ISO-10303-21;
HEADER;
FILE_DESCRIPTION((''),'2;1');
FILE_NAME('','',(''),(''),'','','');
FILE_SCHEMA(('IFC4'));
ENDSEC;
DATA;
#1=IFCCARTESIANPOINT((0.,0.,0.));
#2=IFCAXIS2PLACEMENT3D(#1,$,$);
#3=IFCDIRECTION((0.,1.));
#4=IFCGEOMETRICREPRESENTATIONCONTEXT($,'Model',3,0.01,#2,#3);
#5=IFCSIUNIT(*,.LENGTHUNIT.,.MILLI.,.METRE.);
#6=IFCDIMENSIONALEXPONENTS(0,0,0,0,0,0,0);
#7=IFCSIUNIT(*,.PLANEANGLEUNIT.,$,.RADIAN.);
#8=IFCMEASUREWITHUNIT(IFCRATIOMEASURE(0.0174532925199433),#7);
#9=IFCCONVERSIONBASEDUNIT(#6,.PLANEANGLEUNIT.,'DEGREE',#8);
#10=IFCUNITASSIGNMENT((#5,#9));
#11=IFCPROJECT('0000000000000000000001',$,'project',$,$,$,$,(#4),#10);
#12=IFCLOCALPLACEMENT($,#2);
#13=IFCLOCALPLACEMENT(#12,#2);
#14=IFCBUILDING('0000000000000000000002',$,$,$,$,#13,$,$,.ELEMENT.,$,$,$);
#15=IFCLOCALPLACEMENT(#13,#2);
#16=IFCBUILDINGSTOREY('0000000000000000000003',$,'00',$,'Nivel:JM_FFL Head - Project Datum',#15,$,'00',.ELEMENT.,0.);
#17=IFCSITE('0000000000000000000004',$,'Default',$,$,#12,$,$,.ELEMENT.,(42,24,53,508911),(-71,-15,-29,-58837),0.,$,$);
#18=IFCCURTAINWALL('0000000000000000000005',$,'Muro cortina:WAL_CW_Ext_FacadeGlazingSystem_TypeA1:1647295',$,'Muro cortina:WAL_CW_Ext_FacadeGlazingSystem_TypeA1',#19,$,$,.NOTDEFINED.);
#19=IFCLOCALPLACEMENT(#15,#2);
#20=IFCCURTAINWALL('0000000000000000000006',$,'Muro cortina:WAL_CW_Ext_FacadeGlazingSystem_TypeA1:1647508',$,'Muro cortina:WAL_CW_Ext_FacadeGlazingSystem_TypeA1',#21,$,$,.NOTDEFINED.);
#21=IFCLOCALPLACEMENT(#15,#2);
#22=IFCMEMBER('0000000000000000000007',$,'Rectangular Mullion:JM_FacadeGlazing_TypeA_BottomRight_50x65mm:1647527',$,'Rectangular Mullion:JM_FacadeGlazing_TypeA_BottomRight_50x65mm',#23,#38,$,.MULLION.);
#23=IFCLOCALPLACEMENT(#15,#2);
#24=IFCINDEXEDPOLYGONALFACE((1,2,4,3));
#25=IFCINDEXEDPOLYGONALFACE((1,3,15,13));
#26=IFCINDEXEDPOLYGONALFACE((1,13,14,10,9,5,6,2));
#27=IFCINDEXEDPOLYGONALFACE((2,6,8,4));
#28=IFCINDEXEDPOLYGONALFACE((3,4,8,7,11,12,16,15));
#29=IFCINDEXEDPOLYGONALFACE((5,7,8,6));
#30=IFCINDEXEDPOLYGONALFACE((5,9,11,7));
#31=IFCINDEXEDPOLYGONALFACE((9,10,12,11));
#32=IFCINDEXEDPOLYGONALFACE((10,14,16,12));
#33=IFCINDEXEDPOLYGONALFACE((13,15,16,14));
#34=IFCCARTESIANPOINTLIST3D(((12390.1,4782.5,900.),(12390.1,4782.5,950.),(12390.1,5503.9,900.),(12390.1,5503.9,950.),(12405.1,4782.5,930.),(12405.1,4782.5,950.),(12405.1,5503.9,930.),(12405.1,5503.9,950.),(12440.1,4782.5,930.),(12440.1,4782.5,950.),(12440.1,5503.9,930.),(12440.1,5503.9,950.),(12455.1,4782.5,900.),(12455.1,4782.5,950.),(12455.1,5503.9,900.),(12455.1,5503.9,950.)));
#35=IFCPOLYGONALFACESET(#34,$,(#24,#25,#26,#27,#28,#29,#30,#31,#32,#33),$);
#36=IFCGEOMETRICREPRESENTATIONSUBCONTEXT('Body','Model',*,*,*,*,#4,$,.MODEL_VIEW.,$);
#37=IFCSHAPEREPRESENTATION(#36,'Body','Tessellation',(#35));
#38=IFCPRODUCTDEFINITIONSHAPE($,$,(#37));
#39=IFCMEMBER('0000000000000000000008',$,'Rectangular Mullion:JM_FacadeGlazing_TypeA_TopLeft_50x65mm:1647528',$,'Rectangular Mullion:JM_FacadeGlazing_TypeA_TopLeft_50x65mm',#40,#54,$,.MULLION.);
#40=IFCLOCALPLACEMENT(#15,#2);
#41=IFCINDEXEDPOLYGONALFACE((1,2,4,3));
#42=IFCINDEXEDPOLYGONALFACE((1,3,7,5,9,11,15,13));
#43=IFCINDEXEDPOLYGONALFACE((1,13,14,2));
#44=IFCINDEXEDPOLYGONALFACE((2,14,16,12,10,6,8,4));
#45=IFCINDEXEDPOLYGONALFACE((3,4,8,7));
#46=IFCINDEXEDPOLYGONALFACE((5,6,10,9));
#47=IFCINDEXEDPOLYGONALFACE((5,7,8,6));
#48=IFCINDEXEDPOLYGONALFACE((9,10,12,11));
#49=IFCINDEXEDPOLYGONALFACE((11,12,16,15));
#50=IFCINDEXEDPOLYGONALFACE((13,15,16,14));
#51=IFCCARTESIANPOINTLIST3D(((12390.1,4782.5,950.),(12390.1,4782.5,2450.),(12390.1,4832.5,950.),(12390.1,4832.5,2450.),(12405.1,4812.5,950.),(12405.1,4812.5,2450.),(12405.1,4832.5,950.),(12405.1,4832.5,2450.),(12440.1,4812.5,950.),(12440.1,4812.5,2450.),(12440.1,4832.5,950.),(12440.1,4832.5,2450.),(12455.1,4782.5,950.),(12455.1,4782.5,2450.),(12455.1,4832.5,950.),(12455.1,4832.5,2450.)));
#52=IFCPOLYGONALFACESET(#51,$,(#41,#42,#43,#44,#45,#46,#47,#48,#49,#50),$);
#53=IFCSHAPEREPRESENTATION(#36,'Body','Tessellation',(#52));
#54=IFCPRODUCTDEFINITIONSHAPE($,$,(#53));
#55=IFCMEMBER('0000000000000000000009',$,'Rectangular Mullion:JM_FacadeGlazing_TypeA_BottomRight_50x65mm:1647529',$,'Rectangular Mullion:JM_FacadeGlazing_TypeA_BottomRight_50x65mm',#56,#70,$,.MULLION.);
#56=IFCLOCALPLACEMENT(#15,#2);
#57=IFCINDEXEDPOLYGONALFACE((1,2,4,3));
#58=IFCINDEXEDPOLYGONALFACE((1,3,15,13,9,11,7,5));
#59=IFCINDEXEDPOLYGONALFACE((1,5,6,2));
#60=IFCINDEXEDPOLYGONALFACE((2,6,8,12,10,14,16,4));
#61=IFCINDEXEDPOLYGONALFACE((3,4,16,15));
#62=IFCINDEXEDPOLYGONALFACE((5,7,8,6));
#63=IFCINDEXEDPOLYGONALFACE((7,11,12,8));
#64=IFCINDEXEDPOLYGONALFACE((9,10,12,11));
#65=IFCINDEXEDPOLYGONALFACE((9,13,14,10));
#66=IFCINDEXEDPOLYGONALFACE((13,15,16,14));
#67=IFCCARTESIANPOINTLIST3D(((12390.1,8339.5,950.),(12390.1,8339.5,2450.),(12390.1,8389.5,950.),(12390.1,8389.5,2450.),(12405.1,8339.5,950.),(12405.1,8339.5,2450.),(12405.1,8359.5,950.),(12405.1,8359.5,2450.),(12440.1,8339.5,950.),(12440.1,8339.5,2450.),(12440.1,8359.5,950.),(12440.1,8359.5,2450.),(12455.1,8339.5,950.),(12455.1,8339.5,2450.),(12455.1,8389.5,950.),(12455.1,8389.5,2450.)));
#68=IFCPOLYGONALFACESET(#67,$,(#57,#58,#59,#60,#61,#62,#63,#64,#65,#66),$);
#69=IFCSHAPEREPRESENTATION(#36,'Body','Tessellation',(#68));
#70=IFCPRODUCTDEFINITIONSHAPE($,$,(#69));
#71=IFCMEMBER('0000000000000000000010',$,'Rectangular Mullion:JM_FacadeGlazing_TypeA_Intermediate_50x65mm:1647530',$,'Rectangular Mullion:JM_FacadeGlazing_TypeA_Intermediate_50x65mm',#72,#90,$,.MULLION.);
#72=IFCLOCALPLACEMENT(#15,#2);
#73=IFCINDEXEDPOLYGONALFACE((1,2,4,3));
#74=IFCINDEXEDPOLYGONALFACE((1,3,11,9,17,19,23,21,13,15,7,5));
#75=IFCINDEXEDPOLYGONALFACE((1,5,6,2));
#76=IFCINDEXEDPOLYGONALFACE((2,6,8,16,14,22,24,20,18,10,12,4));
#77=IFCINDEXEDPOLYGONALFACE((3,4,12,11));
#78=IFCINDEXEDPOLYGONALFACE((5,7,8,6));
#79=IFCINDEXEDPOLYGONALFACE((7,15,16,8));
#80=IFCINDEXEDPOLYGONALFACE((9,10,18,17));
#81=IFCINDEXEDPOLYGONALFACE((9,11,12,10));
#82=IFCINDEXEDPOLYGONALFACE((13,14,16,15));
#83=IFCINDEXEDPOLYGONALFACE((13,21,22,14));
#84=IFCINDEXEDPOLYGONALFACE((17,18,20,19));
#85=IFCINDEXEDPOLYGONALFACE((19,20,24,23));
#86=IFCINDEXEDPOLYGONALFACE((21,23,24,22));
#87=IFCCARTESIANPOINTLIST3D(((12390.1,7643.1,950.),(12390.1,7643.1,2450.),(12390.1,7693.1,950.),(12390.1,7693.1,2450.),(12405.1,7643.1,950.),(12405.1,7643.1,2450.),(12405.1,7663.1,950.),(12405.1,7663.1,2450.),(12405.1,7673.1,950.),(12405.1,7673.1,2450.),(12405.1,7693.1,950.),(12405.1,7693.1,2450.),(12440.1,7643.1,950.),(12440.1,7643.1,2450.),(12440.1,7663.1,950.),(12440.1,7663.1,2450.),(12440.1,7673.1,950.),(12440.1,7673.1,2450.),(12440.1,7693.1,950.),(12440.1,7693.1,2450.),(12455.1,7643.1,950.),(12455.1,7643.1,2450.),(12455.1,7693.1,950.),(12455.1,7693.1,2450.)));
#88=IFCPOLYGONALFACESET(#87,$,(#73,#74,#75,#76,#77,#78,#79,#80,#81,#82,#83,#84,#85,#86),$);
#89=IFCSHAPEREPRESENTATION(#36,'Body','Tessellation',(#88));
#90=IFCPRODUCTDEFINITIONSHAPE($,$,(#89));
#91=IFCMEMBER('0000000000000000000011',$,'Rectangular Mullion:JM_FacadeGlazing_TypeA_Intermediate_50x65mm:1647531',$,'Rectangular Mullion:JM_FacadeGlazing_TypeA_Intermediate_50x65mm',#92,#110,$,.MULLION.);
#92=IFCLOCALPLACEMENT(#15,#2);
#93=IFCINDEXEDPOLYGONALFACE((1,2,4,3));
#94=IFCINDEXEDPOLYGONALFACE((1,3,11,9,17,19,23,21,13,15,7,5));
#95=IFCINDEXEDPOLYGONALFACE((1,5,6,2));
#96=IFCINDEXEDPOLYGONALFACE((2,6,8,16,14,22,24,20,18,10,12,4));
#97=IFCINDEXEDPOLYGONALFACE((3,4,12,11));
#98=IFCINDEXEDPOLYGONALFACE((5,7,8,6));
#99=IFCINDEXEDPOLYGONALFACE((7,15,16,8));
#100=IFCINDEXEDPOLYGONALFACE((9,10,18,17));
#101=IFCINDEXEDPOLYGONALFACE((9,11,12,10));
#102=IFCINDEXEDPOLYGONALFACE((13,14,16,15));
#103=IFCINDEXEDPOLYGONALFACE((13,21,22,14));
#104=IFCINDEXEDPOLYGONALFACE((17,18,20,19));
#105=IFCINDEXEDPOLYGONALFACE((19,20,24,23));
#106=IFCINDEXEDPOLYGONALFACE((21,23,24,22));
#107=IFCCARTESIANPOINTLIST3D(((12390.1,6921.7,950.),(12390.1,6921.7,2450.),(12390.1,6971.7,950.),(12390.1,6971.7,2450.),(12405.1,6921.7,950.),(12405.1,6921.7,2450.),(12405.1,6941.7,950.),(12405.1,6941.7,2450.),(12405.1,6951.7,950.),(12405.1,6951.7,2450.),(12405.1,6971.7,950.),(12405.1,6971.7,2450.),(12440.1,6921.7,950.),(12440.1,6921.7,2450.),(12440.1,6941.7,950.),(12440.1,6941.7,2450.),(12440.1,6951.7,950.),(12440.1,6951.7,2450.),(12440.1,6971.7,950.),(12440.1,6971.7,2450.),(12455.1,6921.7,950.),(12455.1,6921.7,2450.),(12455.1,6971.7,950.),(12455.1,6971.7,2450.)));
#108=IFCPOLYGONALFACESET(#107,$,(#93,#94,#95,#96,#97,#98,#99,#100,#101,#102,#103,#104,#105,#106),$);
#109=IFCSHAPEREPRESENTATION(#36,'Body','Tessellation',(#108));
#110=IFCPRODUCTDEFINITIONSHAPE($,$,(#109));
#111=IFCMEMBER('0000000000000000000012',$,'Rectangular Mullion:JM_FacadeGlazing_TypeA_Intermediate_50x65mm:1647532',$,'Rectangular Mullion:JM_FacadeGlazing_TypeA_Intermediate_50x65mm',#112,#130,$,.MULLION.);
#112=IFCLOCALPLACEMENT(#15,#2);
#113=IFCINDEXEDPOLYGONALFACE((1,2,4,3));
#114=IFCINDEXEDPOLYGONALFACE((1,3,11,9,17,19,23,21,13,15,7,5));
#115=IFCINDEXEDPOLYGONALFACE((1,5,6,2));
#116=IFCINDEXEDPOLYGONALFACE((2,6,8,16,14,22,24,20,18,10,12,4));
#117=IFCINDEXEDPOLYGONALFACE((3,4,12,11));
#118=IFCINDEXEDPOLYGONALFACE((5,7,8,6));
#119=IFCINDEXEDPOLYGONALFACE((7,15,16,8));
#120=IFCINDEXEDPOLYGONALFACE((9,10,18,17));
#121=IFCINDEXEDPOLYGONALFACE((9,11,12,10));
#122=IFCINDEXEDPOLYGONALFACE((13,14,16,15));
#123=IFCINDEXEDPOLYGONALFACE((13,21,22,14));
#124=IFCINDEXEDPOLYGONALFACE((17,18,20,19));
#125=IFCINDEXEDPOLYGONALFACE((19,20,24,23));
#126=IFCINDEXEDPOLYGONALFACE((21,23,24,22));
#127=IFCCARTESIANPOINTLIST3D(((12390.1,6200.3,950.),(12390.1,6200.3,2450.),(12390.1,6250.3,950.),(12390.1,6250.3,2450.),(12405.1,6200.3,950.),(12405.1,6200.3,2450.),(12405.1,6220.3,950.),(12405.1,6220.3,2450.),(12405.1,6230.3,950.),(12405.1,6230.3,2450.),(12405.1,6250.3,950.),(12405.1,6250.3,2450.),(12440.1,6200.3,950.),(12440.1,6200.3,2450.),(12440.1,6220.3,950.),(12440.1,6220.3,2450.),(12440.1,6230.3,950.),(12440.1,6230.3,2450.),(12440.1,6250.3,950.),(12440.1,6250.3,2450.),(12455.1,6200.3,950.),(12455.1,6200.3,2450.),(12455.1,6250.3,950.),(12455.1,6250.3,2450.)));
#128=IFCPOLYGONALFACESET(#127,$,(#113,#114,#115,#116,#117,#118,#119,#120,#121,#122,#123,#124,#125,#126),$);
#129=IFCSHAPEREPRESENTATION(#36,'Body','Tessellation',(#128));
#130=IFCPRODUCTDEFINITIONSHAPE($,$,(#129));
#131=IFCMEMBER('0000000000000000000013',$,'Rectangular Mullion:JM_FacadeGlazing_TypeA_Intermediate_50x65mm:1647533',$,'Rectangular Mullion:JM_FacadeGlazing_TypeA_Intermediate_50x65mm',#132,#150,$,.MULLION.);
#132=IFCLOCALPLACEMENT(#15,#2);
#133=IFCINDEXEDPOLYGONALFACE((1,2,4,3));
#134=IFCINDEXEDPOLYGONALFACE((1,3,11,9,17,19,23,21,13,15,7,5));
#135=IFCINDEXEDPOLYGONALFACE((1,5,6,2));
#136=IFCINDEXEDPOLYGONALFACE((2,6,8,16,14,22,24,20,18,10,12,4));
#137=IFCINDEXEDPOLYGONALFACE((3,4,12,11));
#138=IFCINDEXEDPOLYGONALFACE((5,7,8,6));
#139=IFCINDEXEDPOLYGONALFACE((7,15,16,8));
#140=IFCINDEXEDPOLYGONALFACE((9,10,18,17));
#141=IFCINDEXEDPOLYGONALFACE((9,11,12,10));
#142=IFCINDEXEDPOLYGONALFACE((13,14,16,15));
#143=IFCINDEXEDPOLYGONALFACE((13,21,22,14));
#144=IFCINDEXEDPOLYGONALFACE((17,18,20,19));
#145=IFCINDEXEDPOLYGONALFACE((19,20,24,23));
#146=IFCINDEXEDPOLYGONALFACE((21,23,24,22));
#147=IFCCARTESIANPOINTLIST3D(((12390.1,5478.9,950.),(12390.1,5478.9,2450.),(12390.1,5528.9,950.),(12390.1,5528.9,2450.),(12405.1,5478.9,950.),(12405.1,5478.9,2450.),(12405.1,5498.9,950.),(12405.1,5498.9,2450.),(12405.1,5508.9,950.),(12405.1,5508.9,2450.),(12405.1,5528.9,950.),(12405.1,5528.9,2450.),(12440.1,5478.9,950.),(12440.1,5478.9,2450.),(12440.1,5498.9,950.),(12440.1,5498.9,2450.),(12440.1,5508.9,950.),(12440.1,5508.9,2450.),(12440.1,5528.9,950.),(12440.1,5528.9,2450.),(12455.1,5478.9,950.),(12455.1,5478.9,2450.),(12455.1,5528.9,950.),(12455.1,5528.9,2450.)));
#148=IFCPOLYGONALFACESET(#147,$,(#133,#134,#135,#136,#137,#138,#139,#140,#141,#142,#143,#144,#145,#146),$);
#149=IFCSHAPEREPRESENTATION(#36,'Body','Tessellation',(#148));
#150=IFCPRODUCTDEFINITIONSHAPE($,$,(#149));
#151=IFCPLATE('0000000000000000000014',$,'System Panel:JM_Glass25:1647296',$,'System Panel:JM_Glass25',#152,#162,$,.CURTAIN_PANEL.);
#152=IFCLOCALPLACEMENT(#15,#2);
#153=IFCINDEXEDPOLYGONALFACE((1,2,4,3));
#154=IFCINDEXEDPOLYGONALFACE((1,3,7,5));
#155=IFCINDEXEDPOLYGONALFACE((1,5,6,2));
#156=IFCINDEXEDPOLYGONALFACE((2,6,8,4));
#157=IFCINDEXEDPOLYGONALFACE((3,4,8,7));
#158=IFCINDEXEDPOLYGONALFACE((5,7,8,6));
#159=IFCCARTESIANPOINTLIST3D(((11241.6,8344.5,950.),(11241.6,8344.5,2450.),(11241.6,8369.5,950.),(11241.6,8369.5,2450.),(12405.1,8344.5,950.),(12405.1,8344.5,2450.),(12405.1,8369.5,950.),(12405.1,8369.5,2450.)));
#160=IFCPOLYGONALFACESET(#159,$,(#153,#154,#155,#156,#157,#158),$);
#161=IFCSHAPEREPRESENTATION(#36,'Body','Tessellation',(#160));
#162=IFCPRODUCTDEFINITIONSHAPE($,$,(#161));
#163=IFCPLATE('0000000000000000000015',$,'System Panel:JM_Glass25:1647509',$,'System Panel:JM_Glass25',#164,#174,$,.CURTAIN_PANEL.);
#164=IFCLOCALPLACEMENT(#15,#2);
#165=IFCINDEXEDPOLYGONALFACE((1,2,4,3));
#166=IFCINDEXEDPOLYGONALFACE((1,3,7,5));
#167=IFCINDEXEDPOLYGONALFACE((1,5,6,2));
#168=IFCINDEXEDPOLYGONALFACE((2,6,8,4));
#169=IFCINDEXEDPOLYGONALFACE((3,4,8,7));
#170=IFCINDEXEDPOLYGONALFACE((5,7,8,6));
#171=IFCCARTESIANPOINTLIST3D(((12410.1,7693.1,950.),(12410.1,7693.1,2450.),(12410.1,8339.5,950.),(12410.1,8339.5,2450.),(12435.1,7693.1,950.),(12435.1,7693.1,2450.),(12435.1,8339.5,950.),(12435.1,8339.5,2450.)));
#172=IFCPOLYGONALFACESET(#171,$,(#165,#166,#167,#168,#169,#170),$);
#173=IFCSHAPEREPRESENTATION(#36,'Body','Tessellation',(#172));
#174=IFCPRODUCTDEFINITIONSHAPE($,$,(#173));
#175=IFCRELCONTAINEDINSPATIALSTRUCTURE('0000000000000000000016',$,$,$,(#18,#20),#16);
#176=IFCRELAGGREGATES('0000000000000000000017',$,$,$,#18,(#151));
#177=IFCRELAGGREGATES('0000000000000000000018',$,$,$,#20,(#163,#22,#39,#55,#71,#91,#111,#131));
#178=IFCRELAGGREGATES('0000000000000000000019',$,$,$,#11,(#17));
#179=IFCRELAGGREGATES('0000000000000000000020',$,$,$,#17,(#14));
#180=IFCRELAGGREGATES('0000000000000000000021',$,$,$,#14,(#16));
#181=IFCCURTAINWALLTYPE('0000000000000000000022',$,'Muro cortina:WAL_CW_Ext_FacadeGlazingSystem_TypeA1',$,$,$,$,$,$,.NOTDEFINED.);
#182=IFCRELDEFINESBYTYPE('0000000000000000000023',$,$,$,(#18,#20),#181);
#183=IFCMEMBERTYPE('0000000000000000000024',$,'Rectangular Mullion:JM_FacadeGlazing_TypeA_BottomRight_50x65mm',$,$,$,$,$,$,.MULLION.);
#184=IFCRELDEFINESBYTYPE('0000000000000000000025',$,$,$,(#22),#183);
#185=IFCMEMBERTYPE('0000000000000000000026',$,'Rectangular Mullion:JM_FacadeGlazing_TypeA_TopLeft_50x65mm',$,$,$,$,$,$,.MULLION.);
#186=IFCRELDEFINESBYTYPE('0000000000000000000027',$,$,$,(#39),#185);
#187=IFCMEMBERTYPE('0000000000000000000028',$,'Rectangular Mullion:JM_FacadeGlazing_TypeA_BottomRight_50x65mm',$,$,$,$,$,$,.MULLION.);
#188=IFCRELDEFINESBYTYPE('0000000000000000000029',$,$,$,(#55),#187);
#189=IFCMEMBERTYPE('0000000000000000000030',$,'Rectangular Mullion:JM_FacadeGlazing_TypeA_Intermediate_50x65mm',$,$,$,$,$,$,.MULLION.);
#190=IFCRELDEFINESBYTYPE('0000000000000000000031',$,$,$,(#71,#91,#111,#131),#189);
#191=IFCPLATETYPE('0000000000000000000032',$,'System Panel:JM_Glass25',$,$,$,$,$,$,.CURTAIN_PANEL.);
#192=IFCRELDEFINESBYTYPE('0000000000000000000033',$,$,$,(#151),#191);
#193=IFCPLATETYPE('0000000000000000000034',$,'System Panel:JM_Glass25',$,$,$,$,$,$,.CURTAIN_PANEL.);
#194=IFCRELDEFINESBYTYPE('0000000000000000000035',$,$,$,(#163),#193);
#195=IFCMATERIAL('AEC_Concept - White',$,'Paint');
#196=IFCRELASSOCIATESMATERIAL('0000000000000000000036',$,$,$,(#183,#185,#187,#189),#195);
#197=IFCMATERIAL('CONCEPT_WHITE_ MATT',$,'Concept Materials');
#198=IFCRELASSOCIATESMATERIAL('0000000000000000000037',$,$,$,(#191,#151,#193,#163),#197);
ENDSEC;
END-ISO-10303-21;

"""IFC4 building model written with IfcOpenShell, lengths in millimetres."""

from ifc_helpers import new_model, entity, si_unit, converted_unit, direction, frame, origin, place, context, subcontext, project, spatial, indexed_curve, outline, extrude, source, transform, mapped, material, type_object, type_shapes, element, aggregate, save


model = new_model("IFC4")

# Units and contexts
model_context = context("Model", 3, precision=0.01, world=origin(), true_north=direction((0.0, 1.0)))
body_context = subcontext(model_context, "Body", "Model", "MODEL_VIEW")
ifc_project = project(units=[si_unit("LENGTHUNIT", "METRE", prefix="MILLI"), converted_unit("PLANEANGLEUNIT", "DEGREE", entity("IfcRatioMeasure", 0.0174532925199433), si_unit("PLANEANGLEUNIT", "RADIAN"), dimensions=[0, 0, 0, 0, 0, 0, 0])], contexts=[model_context])

# Site, building, storey
site_placement = place(None, origin())
site = spatial("IfcSite", under=ifc_project, at=site_placement, Name="Default", CompositionType="ELEMENT", RefLatitude=(42, 24, 53, 508911), RefLongitude=(-71, -15, -29, -58837), RefElevation=0.0)
building_placement = place(site_placement, origin())
building = spatial("IfcBuilding", under=site, at=building_placement, CompositionType="ELEMENT")
storey_placement = place(building_placement, origin())
storey = spatial("IfcBuildingStorey", under=building, at=storey_placement, Name="00", ObjectType="Nivel:JM_FFL Head - Project Datum", LongName="00", CompositionType="ELEMENT", Elevation=0.0)

# Curtain walls, members
curtain_wall_type = type_object("IfcCurtainWallType", Name="Muro cortina:WAL_CW_Ext_FacadeGlazingSystem_TypeA1", PredefinedType="NOTDEFINED")
curtain_wall_1_placement = place(storey_placement, origin())
curtain_wall_1 = element("IfcCurtainWall", 1, at=curtain_wall_1_placement, inside=storey, type_object=curtain_wall_type, Name="Muro cortina:WAL_CW_Ext_FacadeGlazingSystem_TypeA1:1647295", ObjectType="Muro cortina:WAL_CW_Ext_FacadeGlazingSystem_TypeA1", PredefinedType="NOTDEFINED")
ifc_material_1 = material(Name="AEC_Concept - White", Category="Paint")
curtain_wall_2_placement = place(storey_placement, origin())
curtain_wall_2 = element("IfcCurtainWall", 2, at=curtain_wall_2_placement, inside=storey, type_object=curtain_wall_type, Name="Muro cortina:WAL_CW_Ext_FacadeGlazingSystem_TypeA1:1647508", ObjectType="Muro cortina:WAL_CW_Ext_FacadeGlazingSystem_TypeA1", PredefinedType="NOTDEFINED")
member_type_1 = type_object("IfcMemberType", Name="Rectangular Mullion:JM_FacadeGlazing_TypeA_BottomRight_50x65mm", PredefinedType="MULLION", material=ifc_material_1)
shared_shape_1 = source(origin(), body_context, "Body", "SweptSolid", [
    extrude(outline(indexed_curve([(-32.5, -17.5), (-17.5, -17.5), (-17.5, 2.5), (17.5, 2.5), (17.5, -17.5), (32.5, -17.5), (32.5, 32.5), (-32.5, 32.5), (-32.5, -17.5)], self_intersect=False)), frame((-32.5, 32.5, -721.4), z_axis=(0.0, 0.0, 1.0), x_axis=(0.0, -1.0, 0.0)), (0.0, 0.0, 1.0), 721.4),
])
type_shapes(member_type_1, [shared_shape_1])
member_1_placement = place(curtain_wall_2_placement, frame((12455.1, 5503.9, 900.0), z_axis=(0.0, 1.0, 0.0), x_axis=(0.0, 0.0, -1.0)))
member_1 = element("IfcMember", 3, at=member_1_placement, type_object=member_type_1, Name="Rectangular Mullion:JM_FacadeGlazing_TypeA_BottomRight_50x65mm:1647527", ObjectType="Rectangular Mullion:JM_FacadeGlazing_TypeA_BottomRight_50x65mm", PredefinedType="MULLION", context=body_context, shape_type="MappedRepresentation", body=[
    mapped(shared_shape_1, transform((0.0, 0.0, 0.0), scale=1.0)),
])
member_type_2 = type_object("IfcMemberType", Name="Rectangular Mullion:JM_FacadeGlazing_TypeA_TopLeft_50x65mm", PredefinedType="MULLION", material=ifc_material_1)
shared_shape_2 = source(origin(), body_context, "Body", "SweptSolid", [
    extrude(outline(indexed_curve([(-32.5, -17.5), (-17.5, -17.5), (-17.5, 2.5), (17.5, 2.5), (17.5, -17.5), (32.5, -17.5), (32.5, 32.5), (-32.5, 32.5), (-32.5, -17.5)], self_intersect=False)), frame((-32.5, 32.5, -1500.0), z_axis=(0.0, 0.0, 1.0), x_axis=(0.0, -1.0, 0.0)), (0.0, 0.0, 1.0), 1500.0),
])
type_shapes(member_type_2, [shared_shape_2])
member_2_placement = place(curtain_wall_2_placement, frame((12455.1, 4782.5, 950.0), z_axis=(0.0, 0.0, -1.0), x_axis=(0.0, -1.0, 0.0)))
member_2 = element("IfcMember", 4, at=member_2_placement, type_object=member_type_2, Name="Rectangular Mullion:JM_FacadeGlazing_TypeA_TopLeft_50x65mm:1647528", ObjectType="Rectangular Mullion:JM_FacadeGlazing_TypeA_TopLeft_50x65mm", PredefinedType="MULLION", context=body_context, shape_type="MappedRepresentation", body=[
    mapped(shared_shape_2, transform((0.0, 0.0, 0.0), scale=1.0)),
])
member_type_3 = type_object("IfcMemberType", Name="Rectangular Mullion:JM_FacadeGlazing_TypeA_BottomRight_50x65mm", PredefinedType="MULLION", material=ifc_material_1)
shared_shape_3 = source(origin(), body_context, "Body", "SweptSolid", [
    extrude(outline(indexed_curve([(-32.5, -17.5), (-17.5, -17.5), (-17.5, 2.5), (17.5, 2.5), (17.5, -17.5), (32.5, -17.5), (32.5, 32.5), (-32.5, 32.5), (-32.5, -17.5)], self_intersect=False)), frame((-32.5, 32.5, -1500.0), z_axis=(0.0, 0.0, 1.0), x_axis=(0.0, -1.0, 0.0)), (0.0, 0.0, 1.0), 1500.0),
])
type_shapes(member_type_3, [shared_shape_3])
member_3_placement = place(curtain_wall_2_placement, frame((12455.1, 8389.5, 2450.0), z_axis=(0.0, 0.0, 1.0), x_axis=(0.0, 1.0, 0.0)))
member_3 = element("IfcMember", 5, at=member_3_placement, type_object=member_type_3, Name="Rectangular Mullion:JM_FacadeGlazing_TypeA_BottomRight_50x65mm:1647529", ObjectType="Rectangular Mullion:JM_FacadeGlazing_TypeA_BottomRight_50x65mm", PredefinedType="MULLION", context=body_context, shape_type="MappedRepresentation", body=[
    mapped(shared_shape_3, transform((0.0, 0.0, 0.0), scale=1.0)),
])
member_type_4 = type_object("IfcMemberType", Name="Rectangular Mullion:JM_FacadeGlazing_TypeA_Intermediate_50x65mm", PredefinedType="MULLION", material=ifc_material_1)
shared_shape_4 = source(origin(), body_context, "Body", "SweptSolid", [
    extrude(outline(indexed_curve([(-32.5, -25.0), (-17.5, -25.0), (-17.5, -5.0), (17.5, -5.0), (17.5, -25.0), (32.5, -25.0), (32.5, 25.0), (17.5, 25.0), (17.5, 5.0), (-17.5, 5.0), (-17.5, 25.0), (-32.5, 25.0), (-32.5, -25.0)], self_intersect=False)), frame((0.0, 32.5, -1500.0), z_axis=(0.0, 0.0, 1.0), x_axis=(0.0, -1.0, 0.0)), (0.0, 0.0, 1.0), 1500.0),
])
type_shapes(member_type_4, [shared_shape_4])
member_4_placement = place(curtain_wall_2_placement, frame((12455.1, 7668.1, 950.0), z_axis=(0.0, 0.0, -1.0), x_axis=(0.0, -1.0, 0.0)))
member_4 = element("IfcMember", 6, at=member_4_placement, type_object=member_type_4, Name="Rectangular Mullion:JM_FacadeGlazing_TypeA_Intermediate_50x65mm:1647530", ObjectType="Rectangular Mullion:JM_FacadeGlazing_TypeA_Intermediate_50x65mm", PredefinedType="MULLION", context=body_context, shape_type="MappedRepresentation", body=[
    mapped(shared_shape_4, transform((0.0, 0.0, 0.0), scale=1.0)),
])
member_5_placement = place(curtain_wall_2_placement, frame((12455.1, 6946.7, 950.0), z_axis=(0.0, 0.0, -1.0), x_axis=(0.0, -1.0, 0.0)))
member_5 = element("IfcMember", 7, at=member_5_placement, type_object=member_type_4, Name="Rectangular Mullion:JM_FacadeGlazing_TypeA_Intermediate_50x65mm:1647531", ObjectType="Rectangular Mullion:JM_FacadeGlazing_TypeA_Intermediate_50x65mm", PredefinedType="MULLION", context=body_context, shape_type="MappedRepresentation", body=[
    mapped(shared_shape_4, transform((0.0, 0.0, 0.0), scale=1.0)),
])
member_6_placement = place(curtain_wall_2_placement, frame((12455.1, 6225.3, 950.0), z_axis=(0.0, 0.0, -1.0), x_axis=(0.0, -1.0, 0.0)))
member_6 = element("IfcMember", 8, at=member_6_placement, type_object=member_type_4, Name="Rectangular Mullion:JM_FacadeGlazing_TypeA_Intermediate_50x65mm:1647532", ObjectType="Rectangular Mullion:JM_FacadeGlazing_TypeA_Intermediate_50x65mm", PredefinedType="MULLION", context=body_context, shape_type="MappedRepresentation", body=[
    mapped(shared_shape_4, transform((0.0, 0.0, 0.0), scale=1.0)),
])
member_7_placement = place(curtain_wall_2_placement, frame((12455.1, 5503.9, 950.0), z_axis=(0.0, 0.0, -1.0), x_axis=(0.0, -1.0, 0.0)))
member_7 = element("IfcMember", 9, at=member_7_placement, type_object=member_type_4, Name="Rectangular Mullion:JM_FacadeGlazing_TypeA_Intermediate_50x65mm:1647533", ObjectType="Rectangular Mullion:JM_FacadeGlazing_TypeA_Intermediate_50x65mm", PredefinedType="MULLION", context=body_context, shape_type="MappedRepresentation", body=[
    mapped(shared_shape_4, transform((0.0, 0.0, 0.0), scale=1.0)),
])

# Plates
ifc_material_2 = material(Name="CONCEPT_WHITE_ MATT", Category="Concept Materials")
plate_type_1 = type_object("IfcPlateType", Name="System Panel:JM_Glass25", PredefinedType="CURTAIN_PANEL", material=ifc_material_2)
shared_shape_5 = source(origin(), body_context, "Body", "SweptSolid", [
    extrude(outline(indexed_curve([(-12.5, -581.7), (12.5, -581.7), (12.5, 581.7), (-12.5, 581.7), (-12.5, -581.7)], self_intersect=False)), frame((0.0, 32.5, 0.0), z_axis=(0.0, 0.0, 1.0), x_axis=(0.0, 1.0, 0.0)), (0.0, 0.0, 1.0), 1500.0),
])
type_shapes(plate_type_1, [shared_shape_5])
plate_1_placement = place(curtain_wall_1_placement, frame((11823.4, 8389.5, 950.0), z_axis=(0.0, 0.0, 1.0), x_axis=(-1.0, 0.0, 0.0)))
plate_1 = element("IfcPlate", 10, at=plate_1_placement, type_object=plate_type_1, material=ifc_material_2, Name="System Panel:JM_Glass25:1647296", ObjectType="System Panel:JM_Glass25", PredefinedType="CURTAIN_PANEL", context=body_context, shape_type="MappedRepresentation", body=[
    mapped(shared_shape_5, transform((0.0, 0.0, 0.0), scale=1.0)),
])
aggregate(curtain_wall_1, [plate_1])
plate_type_2 = type_object("IfcPlateType", Name="System Panel:JM_Glass25", PredefinedType="CURTAIN_PANEL", material=ifc_material_2)
shared_shape_6 = source(origin(), body_context, "Body", "SweptSolid", [
    extrude(outline(indexed_curve([(-12.5, -323.2), (12.5, -323.2), (12.5, 323.2), (-12.5, 323.2), (-12.5, -323.2)], self_intersect=False)), frame((0.0, -32.5, 0.0), z_axis=(0.0, 0.0, 1.0), x_axis=(0.0, 1.0, 0.0)), (0.0, 0.0, 1.0), 1500.0),
])
type_shapes(plate_type_2, [shared_shape_6])
plate_2_placement = place(curtain_wall_2_placement, frame((12455.1, 8016.3, 950.0), z_axis=(0.0, 0.0, 1.0), x_axis=(0.0, -1.0, 0.0)))
plate_2 = element("IfcPlate", 11, at=plate_2_placement, type_object=plate_type_2, material=ifc_material_2, Name="System Panel:JM_Glass25:1647509", ObjectType="System Panel:JM_Glass25", PredefinedType="CURTAIN_PANEL", context=body_context, shape_type="MappedRepresentation", body=[
    mapped(shared_shape_6, transform((0.0, 0.0, 0.0), scale=1.0)),
])
aggregate(curtain_wall_2, [plate_2, member_1, member_2, member_3, member_4, member_5, member_6, member_7])

save(model, "model.ifc")
